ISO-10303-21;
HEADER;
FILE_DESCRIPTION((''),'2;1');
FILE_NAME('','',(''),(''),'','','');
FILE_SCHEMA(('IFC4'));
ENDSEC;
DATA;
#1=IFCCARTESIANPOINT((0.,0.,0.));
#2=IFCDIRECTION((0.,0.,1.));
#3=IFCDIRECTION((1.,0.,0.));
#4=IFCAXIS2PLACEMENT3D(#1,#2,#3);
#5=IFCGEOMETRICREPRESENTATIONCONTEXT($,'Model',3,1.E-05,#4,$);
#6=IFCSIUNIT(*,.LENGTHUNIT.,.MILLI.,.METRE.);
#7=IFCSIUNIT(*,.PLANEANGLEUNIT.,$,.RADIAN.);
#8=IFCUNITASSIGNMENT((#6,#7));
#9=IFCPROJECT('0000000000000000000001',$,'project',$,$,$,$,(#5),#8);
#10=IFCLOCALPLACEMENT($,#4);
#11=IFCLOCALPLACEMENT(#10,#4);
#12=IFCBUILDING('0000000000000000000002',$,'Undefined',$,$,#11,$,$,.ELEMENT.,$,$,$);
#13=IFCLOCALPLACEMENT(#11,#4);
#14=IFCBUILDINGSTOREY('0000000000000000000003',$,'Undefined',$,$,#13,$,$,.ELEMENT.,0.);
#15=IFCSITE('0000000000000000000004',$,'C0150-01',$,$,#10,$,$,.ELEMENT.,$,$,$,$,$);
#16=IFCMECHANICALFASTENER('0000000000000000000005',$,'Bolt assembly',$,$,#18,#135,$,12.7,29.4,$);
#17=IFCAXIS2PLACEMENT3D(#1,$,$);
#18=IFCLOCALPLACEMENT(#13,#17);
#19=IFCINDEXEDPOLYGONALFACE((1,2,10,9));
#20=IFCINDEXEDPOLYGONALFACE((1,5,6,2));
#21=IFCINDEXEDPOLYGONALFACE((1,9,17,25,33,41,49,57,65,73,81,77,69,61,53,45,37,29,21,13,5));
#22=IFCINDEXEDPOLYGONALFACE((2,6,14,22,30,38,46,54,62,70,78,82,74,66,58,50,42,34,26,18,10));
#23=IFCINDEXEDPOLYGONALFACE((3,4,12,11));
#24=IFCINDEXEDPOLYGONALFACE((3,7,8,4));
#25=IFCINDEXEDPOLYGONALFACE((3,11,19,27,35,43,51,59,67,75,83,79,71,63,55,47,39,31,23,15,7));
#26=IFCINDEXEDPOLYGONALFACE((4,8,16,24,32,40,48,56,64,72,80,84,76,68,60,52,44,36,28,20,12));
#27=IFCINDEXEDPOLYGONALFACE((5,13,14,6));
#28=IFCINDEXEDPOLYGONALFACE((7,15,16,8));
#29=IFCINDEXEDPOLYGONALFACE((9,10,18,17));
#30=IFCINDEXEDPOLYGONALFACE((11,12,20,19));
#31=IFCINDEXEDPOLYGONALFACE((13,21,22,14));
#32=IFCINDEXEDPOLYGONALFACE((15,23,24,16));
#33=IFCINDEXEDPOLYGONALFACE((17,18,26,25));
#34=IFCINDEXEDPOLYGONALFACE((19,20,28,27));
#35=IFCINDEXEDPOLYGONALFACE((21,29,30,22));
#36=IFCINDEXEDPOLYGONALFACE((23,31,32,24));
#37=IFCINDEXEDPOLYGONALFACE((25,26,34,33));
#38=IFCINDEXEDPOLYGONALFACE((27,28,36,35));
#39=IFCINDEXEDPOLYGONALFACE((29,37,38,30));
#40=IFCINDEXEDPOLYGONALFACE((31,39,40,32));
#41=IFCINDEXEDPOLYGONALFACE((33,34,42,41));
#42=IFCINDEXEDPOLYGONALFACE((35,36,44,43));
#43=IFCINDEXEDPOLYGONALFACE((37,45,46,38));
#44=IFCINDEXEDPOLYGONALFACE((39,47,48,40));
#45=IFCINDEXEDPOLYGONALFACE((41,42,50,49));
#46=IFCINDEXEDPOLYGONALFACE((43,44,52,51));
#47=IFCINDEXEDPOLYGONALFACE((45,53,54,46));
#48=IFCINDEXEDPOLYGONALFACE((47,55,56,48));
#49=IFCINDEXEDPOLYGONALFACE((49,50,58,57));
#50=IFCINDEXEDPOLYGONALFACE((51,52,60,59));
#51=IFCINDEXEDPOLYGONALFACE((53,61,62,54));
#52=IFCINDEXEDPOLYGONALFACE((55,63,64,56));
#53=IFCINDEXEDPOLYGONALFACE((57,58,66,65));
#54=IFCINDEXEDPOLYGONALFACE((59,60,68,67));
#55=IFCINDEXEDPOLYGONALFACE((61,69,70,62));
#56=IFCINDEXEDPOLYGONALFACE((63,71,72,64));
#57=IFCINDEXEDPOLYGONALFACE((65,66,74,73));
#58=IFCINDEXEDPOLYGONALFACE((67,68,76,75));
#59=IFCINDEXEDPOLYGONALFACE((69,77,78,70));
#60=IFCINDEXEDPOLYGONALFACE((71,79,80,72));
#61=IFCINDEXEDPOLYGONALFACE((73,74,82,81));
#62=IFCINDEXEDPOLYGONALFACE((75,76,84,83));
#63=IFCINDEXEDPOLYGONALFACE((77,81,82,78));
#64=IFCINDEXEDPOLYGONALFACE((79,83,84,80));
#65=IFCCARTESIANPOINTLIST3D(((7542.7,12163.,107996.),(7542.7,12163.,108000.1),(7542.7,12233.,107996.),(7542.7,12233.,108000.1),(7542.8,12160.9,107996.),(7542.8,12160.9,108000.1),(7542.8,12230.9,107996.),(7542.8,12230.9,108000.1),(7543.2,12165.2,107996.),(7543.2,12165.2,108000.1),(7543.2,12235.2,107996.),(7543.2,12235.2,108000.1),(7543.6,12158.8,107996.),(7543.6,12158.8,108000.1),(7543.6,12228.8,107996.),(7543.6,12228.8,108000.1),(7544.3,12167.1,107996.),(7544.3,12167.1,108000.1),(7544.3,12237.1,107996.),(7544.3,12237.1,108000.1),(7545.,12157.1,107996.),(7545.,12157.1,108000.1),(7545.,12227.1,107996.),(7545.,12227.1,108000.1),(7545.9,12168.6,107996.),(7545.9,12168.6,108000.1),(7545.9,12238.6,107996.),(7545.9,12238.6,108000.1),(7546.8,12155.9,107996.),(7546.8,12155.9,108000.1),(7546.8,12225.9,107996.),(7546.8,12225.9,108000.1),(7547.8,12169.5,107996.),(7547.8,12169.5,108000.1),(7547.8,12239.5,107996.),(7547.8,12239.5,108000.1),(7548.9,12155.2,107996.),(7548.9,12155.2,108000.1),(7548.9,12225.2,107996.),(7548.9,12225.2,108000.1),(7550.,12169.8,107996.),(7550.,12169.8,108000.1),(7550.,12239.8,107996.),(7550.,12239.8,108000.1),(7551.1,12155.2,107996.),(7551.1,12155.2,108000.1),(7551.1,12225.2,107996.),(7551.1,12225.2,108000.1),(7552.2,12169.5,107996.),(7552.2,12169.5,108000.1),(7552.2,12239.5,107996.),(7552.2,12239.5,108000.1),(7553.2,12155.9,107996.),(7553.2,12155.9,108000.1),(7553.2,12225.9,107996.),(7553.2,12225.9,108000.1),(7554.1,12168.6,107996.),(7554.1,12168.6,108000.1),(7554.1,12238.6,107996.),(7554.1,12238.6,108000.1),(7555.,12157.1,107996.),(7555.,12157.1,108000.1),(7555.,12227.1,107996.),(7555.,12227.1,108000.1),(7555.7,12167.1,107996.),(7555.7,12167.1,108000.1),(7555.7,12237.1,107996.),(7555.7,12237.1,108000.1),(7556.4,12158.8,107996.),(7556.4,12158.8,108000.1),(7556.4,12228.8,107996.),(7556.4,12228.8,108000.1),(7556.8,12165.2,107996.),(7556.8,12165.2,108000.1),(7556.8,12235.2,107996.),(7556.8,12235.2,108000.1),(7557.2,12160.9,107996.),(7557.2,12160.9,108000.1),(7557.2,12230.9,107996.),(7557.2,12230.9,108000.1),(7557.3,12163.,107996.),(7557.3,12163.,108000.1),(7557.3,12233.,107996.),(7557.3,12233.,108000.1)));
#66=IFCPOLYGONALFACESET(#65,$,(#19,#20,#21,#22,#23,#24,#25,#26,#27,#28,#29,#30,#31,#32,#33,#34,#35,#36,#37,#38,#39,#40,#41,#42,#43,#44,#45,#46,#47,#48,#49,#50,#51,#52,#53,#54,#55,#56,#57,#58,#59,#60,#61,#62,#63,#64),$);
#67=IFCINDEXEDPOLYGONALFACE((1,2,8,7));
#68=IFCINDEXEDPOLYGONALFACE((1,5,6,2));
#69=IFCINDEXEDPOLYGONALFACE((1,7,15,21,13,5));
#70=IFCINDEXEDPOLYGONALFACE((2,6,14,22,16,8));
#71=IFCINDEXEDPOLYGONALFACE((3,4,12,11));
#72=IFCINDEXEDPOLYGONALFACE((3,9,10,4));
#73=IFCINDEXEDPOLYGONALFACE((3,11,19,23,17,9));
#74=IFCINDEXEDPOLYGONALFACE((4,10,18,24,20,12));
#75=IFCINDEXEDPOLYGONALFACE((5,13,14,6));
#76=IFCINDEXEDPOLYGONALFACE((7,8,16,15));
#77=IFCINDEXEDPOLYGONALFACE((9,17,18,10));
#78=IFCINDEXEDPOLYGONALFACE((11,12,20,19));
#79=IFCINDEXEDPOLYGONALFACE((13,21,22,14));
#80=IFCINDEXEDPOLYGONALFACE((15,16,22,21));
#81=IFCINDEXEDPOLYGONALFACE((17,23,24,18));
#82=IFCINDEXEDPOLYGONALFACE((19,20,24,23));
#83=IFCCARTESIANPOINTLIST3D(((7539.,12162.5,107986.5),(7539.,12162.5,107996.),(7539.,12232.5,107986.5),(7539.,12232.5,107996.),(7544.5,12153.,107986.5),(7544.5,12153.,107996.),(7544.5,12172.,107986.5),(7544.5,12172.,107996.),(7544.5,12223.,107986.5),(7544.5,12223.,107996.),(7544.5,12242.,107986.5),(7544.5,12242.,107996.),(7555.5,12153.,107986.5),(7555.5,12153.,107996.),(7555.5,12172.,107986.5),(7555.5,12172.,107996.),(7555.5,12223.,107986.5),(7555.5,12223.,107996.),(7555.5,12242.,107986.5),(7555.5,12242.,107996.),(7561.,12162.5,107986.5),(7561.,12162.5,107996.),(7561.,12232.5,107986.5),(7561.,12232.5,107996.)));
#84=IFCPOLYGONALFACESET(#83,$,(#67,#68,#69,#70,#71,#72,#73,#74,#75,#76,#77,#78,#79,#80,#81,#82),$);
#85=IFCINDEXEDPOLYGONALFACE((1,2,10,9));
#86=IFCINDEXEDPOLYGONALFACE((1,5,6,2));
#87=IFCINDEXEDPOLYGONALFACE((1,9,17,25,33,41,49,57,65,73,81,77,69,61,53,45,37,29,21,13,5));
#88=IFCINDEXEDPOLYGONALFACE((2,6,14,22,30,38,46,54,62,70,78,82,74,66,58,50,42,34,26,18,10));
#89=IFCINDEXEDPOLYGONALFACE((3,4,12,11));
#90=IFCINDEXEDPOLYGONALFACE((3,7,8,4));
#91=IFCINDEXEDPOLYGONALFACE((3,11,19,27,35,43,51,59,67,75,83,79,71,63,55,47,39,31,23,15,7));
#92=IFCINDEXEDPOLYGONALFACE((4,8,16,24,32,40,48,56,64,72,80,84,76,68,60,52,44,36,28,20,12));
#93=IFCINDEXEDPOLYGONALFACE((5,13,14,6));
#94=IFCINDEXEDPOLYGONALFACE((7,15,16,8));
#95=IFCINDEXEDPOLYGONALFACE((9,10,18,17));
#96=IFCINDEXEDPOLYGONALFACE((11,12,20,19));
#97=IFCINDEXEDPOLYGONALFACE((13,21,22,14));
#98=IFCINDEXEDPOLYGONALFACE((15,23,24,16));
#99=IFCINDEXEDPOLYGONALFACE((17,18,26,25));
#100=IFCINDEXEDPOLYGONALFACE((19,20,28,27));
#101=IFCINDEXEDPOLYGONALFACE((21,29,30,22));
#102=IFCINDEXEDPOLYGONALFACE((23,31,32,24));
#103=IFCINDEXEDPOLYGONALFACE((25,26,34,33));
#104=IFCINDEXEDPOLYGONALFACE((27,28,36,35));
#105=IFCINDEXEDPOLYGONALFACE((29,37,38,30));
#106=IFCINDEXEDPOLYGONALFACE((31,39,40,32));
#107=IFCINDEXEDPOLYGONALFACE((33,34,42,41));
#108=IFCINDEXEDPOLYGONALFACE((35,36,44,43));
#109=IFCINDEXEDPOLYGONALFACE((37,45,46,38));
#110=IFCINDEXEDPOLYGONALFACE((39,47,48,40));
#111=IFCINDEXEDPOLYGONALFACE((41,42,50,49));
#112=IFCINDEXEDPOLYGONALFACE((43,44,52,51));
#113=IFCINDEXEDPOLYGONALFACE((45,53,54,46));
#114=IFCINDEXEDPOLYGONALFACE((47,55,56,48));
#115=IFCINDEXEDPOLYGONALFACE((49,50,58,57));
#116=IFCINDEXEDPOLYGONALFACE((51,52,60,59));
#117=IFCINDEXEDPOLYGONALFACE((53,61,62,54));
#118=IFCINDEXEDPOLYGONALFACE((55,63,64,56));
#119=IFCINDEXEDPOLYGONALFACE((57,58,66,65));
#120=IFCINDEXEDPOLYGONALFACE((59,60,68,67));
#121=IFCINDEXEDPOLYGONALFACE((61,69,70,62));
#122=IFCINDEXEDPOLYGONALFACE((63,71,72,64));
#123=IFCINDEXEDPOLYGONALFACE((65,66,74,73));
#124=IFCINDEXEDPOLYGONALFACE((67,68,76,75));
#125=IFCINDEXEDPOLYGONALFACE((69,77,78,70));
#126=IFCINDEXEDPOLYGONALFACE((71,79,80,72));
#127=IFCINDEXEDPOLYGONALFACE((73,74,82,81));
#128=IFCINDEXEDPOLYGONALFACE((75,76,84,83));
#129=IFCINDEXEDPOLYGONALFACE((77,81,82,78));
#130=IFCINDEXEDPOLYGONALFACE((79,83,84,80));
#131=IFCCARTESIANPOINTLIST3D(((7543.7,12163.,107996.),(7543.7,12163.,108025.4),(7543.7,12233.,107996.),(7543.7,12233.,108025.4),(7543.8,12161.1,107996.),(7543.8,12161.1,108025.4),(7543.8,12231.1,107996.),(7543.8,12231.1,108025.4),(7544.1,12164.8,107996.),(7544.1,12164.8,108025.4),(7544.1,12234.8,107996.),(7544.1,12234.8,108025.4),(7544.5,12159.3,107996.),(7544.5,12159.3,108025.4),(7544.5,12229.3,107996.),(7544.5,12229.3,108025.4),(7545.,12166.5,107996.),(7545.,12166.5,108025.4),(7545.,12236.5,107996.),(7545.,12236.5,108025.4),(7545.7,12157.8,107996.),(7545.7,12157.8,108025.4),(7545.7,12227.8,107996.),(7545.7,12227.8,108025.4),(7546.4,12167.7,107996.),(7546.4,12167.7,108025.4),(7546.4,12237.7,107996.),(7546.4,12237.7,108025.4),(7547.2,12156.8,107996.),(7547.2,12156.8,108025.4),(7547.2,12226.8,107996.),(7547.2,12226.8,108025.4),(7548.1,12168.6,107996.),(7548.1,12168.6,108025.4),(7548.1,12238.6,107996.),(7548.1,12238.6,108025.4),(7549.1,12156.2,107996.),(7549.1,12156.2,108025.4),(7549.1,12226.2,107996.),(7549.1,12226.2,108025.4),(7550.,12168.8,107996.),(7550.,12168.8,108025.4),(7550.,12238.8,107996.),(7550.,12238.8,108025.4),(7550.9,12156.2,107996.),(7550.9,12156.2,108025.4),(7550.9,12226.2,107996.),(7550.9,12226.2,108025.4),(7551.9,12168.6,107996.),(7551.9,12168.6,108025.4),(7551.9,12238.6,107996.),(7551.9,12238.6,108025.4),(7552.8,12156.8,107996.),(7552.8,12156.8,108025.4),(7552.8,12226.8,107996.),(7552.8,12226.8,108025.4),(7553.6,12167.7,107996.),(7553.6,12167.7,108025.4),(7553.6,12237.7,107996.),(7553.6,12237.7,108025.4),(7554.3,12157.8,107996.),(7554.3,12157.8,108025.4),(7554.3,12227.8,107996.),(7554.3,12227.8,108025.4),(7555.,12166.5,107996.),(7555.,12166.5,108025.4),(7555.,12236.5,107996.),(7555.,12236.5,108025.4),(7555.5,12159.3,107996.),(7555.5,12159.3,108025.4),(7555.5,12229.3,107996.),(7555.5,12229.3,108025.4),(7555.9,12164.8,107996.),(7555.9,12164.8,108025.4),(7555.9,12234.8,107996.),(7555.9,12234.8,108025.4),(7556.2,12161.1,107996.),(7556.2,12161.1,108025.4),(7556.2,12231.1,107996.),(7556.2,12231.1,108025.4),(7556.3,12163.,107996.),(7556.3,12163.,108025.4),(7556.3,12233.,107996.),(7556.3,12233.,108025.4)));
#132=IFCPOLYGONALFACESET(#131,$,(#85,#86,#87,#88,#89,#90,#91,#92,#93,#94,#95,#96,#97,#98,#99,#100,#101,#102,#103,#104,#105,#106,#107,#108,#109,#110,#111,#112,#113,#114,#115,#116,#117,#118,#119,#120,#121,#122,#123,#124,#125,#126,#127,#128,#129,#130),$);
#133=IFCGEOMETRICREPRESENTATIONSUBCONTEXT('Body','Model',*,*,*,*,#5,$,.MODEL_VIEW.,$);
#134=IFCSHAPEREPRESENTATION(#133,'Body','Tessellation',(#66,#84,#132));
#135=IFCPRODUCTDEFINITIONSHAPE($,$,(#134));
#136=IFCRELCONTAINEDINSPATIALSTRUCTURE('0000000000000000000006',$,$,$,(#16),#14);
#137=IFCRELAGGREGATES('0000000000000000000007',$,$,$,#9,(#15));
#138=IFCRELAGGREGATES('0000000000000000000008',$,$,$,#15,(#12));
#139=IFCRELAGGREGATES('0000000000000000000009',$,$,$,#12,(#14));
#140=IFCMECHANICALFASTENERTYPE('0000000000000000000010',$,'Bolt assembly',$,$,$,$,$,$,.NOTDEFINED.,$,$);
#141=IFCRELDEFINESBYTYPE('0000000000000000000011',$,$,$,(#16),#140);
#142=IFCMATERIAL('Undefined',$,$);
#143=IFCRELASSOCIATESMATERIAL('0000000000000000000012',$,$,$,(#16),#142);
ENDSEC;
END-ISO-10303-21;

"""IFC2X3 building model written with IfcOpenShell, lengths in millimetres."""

from ifc_helpers import new_model, si_unit, frame, origin_with_axes, origin_2d_with_axis, place, context, subcontext, project, spatial, polyline, circle, outline, extrude, source, transform, mapped, material, type_object, element, save


model = new_model("IFC2X3")

# Units and contexts
model_context = context("Model", 3, precision=1e-05, world=origin_with_axes())
body_context = subcontext(model_context, "Body", "Model", "MODEL_VIEW")
ifc_project = project(units=[si_unit("LENGTHUNIT", "METRE", prefix="MILLI"), si_unit("PLANEANGLEUNIT", "RADIAN")], contexts=[model_context])

# Site, building, storey
site_placement = place(None, origin_with_axes())
site = spatial("IfcSite", under=ifc_project, at=site_placement, Name="C0150-01", CompositionType="ELEMENT")
building_placement = place(site_placement, origin_with_axes())
building = spatial("IfcBuilding", under=site, at=building_placement, Name="Undefined", CompositionType="ELEMENT")
storey_placement = place(building_placement, origin_with_axes())
storey = spatial("IfcBuildingStorey", under=building, at=storey_placement, Name="Undefined", CompositionType="ELEMENT", Elevation=0.0)

# Mechanical fastener
ifc_material_1 = material(Name="Undefined")
mechanical_fastener_type = type_object("IfcMechanicalFastenerType", Name="Bolt assembly")
shared_shape_1 = source(origin_with_axes(), body_context, "Body", "SweptSolid", [
    extrude(circle(Radius=7.3, at=origin_2d_with_axis()), frame((0.0, 0.0, 0.0), z_axis=(0.0, 1.0, 0.0), x_axis=(1.0, 0.0, 0.0)), (0.0, 0.0, 1.0), 4.1),
    extrude(outline(polyline([(9.5, -5.5), (9.5, 5.5), (0.0, 11.0), (-9.5, 5.5), (-9.5, -5.5), (0.0, -11.0), (9.5, -5.5)])), frame((0.0, -9.5, 0.0), z_axis=(0.0, 1.0, 0.0), x_axis=(1.0, 0.0, 0.0)), (0.0, 0.0, 1.0), 9.5),
    extrude(circle(Radius=6.3, at=origin_2d_with_axis()), frame((0.0, 0.0, 0.0), z_axis=(0.0, 1.0, 0.0), x_axis=(1.0, 0.0, 0.0)), (0.0, 0.0, 1.0), 29.4),
])
for number, where, z_axis, x_axis, name in (
    (1, (7550.0, 12162.5, 107996.0), (1.0, 0.0, 0.0), (0.0, 1.0, 0.0), "Bolt assembly"),
):
    element("IfcMechanicalFastener", number, at=place(storey_placement, frame(where, z_axis=z_axis, x_axis=x_axis)), inside=storey, type_object=mechanical_fastener_type, material=ifc_material_1, Name=name, NominalDiameter=12.7, NominalLength=29.4, context=body_context, shape_type="MappedRepresentation", body=[
        mapped(shared_shape_1, transform((0.0, 0.0, 0.0))),
        mapped(shared_shape_1, transform((70.0, 0.0, 0.0))),
    ])

save(model, "model.ifc")
